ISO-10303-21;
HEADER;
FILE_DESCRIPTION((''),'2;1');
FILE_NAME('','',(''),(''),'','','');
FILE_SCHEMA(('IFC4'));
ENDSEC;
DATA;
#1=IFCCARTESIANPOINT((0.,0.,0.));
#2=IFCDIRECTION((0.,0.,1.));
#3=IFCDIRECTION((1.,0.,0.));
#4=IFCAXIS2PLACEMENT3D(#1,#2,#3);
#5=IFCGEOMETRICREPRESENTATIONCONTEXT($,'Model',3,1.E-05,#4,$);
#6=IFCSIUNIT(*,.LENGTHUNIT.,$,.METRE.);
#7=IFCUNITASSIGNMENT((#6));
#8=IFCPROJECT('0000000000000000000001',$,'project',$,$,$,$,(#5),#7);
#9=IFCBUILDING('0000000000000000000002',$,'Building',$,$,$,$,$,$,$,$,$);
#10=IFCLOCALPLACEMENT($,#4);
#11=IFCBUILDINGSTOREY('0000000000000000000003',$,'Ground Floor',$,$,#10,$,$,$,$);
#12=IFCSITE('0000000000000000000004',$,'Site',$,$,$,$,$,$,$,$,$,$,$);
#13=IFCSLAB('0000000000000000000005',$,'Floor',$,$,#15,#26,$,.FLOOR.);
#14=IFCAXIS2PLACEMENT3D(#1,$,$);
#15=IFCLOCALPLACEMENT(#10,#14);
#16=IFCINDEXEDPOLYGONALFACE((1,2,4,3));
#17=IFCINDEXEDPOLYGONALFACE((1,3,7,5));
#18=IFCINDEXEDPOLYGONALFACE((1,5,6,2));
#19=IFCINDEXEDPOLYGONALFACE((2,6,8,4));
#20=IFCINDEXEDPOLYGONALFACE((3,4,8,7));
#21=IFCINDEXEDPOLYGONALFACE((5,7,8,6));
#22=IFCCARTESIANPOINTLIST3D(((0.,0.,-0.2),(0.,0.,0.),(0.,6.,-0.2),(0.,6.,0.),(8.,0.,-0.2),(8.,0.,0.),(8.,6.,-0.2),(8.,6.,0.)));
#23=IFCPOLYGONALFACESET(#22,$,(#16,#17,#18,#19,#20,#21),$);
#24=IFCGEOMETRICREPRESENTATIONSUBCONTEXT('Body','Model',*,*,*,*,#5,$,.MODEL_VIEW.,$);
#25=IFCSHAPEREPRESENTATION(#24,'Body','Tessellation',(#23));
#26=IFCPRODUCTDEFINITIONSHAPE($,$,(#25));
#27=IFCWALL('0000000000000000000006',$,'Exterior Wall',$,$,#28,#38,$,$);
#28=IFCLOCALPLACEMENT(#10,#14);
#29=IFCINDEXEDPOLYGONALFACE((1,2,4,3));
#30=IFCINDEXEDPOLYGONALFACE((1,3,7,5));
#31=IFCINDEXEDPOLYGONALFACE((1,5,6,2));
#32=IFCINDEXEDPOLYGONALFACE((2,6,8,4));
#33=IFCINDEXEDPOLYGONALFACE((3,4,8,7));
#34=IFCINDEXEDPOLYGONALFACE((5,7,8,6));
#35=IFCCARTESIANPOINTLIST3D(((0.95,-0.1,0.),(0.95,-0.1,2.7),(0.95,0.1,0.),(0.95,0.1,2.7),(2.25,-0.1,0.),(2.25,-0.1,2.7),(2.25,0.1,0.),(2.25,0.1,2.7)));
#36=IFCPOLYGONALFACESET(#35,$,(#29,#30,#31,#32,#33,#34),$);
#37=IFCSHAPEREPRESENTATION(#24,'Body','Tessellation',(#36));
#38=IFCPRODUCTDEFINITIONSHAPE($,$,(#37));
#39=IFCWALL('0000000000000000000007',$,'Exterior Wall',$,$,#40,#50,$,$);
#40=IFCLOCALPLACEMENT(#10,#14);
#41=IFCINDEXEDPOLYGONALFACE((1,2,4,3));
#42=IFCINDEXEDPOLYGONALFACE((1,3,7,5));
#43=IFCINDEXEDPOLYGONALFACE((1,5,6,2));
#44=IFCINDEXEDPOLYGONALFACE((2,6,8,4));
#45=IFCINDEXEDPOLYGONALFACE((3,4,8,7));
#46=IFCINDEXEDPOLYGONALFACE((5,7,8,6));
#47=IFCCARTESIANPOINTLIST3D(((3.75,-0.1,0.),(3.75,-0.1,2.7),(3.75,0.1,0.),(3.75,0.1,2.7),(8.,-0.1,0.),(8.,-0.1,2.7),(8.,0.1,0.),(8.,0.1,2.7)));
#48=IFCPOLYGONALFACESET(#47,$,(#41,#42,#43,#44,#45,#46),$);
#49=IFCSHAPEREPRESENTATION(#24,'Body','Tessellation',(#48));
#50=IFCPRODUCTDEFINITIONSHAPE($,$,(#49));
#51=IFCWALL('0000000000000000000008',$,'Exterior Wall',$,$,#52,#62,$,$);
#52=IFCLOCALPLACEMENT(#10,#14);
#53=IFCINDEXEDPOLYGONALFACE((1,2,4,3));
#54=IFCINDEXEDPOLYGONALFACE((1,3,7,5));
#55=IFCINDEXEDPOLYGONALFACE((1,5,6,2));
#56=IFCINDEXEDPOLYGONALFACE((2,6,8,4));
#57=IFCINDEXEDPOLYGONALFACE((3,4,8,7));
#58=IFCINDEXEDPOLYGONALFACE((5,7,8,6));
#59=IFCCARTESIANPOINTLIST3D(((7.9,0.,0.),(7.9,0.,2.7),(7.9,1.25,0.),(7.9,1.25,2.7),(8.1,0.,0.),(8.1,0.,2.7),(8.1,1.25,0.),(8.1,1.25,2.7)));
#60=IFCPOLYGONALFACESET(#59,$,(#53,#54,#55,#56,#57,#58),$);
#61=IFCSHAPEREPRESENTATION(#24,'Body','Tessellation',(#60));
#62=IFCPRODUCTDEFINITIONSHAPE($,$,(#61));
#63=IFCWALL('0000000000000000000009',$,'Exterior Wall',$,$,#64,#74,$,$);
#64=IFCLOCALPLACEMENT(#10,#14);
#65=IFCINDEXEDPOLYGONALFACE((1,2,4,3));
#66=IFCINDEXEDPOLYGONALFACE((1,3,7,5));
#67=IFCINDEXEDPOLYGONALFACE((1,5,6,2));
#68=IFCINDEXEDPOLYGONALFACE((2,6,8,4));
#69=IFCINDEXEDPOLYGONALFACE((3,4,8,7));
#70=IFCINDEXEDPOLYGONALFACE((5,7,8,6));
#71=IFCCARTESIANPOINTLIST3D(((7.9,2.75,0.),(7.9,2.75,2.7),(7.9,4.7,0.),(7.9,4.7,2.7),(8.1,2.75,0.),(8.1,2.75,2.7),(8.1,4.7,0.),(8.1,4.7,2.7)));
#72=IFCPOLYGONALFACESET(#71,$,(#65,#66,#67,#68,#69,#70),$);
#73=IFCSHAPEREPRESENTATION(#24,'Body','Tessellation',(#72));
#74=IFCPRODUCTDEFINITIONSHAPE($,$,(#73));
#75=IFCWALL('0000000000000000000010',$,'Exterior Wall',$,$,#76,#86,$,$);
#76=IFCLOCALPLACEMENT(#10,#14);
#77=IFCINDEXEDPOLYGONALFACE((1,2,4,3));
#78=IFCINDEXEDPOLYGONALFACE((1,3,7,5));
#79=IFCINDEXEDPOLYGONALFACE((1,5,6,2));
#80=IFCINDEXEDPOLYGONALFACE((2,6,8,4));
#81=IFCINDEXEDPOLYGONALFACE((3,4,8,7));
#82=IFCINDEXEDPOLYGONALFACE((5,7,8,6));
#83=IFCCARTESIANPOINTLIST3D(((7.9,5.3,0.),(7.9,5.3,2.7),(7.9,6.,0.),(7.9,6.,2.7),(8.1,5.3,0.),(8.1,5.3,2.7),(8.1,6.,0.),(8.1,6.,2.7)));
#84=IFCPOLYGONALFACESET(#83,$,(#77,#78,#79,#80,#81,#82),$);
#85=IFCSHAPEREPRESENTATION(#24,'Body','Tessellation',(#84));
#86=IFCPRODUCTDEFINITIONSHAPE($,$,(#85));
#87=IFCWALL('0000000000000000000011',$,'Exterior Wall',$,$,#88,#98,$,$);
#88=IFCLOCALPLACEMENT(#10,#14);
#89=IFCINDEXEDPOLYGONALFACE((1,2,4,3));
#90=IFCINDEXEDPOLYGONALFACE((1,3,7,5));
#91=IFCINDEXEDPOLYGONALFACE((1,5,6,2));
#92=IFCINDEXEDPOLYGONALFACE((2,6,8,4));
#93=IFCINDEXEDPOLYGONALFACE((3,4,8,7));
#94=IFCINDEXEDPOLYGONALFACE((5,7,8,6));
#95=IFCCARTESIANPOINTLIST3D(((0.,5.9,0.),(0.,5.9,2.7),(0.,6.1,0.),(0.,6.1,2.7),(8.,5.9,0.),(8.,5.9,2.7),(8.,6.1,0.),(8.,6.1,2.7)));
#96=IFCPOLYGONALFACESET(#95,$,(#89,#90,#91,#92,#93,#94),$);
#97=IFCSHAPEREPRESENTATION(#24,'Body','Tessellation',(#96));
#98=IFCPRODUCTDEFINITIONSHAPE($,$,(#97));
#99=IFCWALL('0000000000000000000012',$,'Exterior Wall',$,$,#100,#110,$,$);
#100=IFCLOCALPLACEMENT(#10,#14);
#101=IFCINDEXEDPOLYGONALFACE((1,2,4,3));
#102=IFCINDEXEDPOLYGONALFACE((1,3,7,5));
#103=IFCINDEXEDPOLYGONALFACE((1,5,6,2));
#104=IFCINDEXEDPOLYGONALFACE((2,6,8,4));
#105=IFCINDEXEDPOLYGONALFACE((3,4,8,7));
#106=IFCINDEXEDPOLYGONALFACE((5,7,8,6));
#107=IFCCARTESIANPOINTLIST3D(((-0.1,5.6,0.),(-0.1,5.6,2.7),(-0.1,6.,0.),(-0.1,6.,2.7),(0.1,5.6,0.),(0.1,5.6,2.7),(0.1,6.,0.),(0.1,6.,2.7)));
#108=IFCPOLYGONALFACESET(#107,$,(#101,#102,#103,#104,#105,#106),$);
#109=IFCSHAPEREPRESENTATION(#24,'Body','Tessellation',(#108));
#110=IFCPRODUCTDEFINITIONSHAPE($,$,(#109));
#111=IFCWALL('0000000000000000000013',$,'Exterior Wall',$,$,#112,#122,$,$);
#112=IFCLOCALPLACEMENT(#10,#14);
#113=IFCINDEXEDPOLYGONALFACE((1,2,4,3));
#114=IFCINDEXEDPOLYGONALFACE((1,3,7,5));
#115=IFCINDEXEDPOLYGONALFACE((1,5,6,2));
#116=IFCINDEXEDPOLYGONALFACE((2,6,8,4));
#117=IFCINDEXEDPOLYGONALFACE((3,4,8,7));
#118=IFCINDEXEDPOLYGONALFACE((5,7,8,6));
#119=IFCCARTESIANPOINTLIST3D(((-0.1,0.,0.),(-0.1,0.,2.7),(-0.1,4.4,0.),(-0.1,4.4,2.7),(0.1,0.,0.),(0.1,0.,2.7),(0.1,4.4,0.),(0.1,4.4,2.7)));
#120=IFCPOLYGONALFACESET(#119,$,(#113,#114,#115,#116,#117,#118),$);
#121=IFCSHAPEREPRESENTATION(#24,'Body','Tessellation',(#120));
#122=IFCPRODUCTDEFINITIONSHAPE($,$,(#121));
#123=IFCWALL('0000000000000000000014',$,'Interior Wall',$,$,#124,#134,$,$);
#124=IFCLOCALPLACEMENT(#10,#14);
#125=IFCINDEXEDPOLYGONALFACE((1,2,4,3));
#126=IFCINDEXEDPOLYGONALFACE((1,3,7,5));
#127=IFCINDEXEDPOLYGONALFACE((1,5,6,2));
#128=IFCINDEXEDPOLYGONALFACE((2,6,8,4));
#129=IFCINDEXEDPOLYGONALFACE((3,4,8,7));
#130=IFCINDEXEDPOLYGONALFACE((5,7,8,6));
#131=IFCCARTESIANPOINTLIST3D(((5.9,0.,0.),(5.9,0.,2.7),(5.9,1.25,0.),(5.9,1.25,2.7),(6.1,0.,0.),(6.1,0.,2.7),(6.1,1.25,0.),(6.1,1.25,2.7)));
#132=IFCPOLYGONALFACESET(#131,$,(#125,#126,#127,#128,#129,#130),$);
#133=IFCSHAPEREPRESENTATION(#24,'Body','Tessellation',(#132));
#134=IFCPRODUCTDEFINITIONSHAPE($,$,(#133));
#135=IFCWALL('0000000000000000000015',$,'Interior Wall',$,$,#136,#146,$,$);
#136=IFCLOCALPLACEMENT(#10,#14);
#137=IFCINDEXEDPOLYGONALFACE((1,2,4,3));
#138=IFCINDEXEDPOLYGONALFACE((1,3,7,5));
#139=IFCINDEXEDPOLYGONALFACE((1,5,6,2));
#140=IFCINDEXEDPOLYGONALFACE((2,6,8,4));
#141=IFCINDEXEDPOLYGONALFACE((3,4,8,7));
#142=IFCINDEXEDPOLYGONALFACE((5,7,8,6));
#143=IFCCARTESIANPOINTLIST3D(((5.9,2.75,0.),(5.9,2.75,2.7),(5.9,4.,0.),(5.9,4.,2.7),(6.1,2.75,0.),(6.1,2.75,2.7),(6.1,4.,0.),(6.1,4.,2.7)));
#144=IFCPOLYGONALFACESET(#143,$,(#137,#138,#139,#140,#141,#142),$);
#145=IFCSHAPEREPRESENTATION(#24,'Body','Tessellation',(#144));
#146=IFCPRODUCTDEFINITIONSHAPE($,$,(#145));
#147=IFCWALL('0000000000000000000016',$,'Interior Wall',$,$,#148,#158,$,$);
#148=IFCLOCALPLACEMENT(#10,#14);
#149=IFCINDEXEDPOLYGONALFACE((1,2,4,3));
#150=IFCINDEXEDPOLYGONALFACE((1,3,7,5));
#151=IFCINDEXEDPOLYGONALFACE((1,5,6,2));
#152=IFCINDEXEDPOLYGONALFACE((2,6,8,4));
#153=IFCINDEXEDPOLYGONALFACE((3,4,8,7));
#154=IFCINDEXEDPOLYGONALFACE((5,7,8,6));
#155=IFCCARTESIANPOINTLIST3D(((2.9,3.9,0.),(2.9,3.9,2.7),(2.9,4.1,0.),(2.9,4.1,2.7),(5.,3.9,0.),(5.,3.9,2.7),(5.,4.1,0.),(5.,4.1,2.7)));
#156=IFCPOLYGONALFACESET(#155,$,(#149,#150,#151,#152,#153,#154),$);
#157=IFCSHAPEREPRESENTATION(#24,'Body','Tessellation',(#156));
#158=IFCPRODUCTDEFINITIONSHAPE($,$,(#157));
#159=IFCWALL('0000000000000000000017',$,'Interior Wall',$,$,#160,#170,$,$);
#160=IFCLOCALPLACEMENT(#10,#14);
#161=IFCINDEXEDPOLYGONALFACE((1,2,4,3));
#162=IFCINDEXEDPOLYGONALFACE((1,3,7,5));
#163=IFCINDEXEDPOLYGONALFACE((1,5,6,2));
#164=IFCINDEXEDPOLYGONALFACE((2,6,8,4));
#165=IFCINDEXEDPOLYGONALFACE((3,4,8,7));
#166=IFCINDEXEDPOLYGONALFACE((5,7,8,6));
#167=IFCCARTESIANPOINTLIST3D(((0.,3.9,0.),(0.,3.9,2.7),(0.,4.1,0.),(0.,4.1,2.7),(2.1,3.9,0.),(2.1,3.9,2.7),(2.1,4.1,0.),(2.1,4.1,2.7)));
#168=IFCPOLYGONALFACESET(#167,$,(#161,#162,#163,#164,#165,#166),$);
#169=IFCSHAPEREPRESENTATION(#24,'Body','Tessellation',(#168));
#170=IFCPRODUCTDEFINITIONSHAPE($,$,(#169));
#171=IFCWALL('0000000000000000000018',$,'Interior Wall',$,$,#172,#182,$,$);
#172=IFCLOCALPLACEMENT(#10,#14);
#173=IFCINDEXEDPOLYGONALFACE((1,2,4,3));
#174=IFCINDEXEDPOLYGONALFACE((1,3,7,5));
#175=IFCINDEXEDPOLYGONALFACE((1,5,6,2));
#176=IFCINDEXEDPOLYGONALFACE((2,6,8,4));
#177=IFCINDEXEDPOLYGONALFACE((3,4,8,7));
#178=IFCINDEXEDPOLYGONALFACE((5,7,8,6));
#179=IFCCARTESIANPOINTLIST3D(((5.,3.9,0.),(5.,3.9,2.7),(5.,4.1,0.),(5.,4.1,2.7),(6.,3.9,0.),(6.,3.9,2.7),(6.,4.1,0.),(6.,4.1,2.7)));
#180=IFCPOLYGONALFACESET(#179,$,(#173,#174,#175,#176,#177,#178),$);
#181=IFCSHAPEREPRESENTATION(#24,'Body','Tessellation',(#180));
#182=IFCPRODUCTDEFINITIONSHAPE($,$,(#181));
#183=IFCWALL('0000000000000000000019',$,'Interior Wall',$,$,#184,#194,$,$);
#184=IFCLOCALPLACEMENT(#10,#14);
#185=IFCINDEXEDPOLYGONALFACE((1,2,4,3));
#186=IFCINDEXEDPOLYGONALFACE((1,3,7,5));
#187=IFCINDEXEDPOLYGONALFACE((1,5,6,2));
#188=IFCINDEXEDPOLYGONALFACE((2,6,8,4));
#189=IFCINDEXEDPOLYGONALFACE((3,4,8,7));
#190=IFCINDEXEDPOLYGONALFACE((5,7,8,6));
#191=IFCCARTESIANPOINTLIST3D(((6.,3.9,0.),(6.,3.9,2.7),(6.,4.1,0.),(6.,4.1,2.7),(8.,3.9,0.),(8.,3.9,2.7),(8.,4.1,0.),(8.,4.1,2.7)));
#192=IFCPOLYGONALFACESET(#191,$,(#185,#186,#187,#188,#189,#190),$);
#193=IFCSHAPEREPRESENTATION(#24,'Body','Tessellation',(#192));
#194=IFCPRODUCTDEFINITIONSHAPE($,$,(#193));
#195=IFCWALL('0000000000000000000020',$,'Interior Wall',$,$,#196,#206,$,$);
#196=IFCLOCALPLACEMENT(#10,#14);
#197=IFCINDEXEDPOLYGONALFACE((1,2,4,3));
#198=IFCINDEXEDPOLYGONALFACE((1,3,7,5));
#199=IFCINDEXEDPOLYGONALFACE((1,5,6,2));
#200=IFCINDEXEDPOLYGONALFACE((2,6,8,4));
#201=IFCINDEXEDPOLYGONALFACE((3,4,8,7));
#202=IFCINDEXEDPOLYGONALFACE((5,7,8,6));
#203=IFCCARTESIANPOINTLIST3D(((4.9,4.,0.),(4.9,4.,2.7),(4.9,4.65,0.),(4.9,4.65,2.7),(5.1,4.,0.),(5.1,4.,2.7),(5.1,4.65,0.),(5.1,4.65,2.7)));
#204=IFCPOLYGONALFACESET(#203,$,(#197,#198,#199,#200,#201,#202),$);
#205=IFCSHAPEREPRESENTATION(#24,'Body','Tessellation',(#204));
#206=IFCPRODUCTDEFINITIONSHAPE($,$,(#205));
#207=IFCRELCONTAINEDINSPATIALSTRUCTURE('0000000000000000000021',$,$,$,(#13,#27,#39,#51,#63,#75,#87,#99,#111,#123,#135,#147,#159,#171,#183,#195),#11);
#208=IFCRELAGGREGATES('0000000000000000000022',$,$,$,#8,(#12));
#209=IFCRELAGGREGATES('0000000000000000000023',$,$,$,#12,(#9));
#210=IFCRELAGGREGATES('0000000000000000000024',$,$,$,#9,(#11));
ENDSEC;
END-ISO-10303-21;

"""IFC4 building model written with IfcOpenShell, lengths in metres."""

from ifc_helpers import new_model, si_unit, frame, origin_with_axes, place, context, subcontext, project, spatial, indexed_curve, outline, extrude, element, save


model = new_model("IFC4")

# Units and contexts
model_context = context("Model", 3, precision=1e-05, world=origin_with_axes())
body_context = subcontext(model_context, "Body", "Model", "MODEL_VIEW")
ifc_project = project(units=[si_unit("LENGTHUNIT", "METRE")], contexts=[model_context])

# Site, building, storey
site = spatial("IfcSite", under=ifc_project, Name="Site")
building = spatial("IfcBuilding", under=site, Name="Building")
storey_placement = place(None, origin_with_axes())
storey = spatial("IfcBuildingStorey", under=building, at=storey_placement, Name="Ground Floor")

# Slab
slab_placement = place(storey_placement, frame((0.0, 0.0, -0.2), z_axis=(0.0, 0.0, 1.0), x_axis=(1.0, 0.0, 0.0)))
element("IfcSlab", 1, at=slab_placement, inside=storey, Name="Floor", PredefinedType="FLOOR", context=body_context, shape_type="SweptSolid", body=[
    extrude(outline(indexed_curve([(0.0, 0.0), (8.0, 0.0), (8.0, 6.0), (0.0, 6.0)])), None, (0.0, 0.0, 1.0), 0.2),
])

# Walls
wall_1_placement = place(storey_placement, frame((0.95, 0.0, 0.0), z_axis=(0.0, 0.0, 1.0), x_axis=(1.0, 0.0, 0.0)))
element("IfcWall", 2, at=wall_1_placement, inside=storey, Name="Exterior Wall", context=body_context, shape_type="SweptSolid", body=[
    extrude(outline(indexed_curve([(0.0, 0.0), (0.0, 0.2), (1.3, 0.2), (1.3, 0.0), (0.0, 0.0)], self_intersect=False)), frame((0.0, -0.1, 0.0), z_axis=(0.0, 0.0, 1.0), x_axis=(1.0, 0.0, 0.0)), (0.0, 0.0, 1.0), 2.7),
])
wall_2_placement = place(storey_placement, frame((3.75, 0.0, 0.0), z_axis=(0.0, 0.0, 1.0), x_axis=(1.0, 0.0, 0.0)))
element("IfcWall", 3, at=wall_2_placement, inside=storey, Name="Exterior Wall", context=body_context, shape_type="SweptSolid", body=[
    extrude(outline(indexed_curve([(0.0, 0.0), (0.0, 0.2), (4.25, 0.2), (4.25, 0.0), (0.0, 0.0)], self_intersect=False)), frame((0.0, -0.1, 0.0), z_axis=(0.0, 0.0, 1.0), x_axis=(1.0, 0.0, 0.0)), (0.0, 0.0, 1.0), 2.7),
])
wall_3_placement = place(storey_placement, frame((8.0, 0.0, 0.0), z_axis=(0.0, 0.0, 1.0), x_axis=(0.0, 1.0, 0.0)))
element("IfcWall", 4, at=wall_3_placement, inside=storey, Name="Exterior Wall", context=body_context, shape_type="SweptSolid", body=[
    extrude(outline(indexed_curve([(0.0, 0.0), (0.0, 0.2), (1.25, 0.2), (1.25, 0.0), (0.0, 0.0)], self_intersect=False)), frame((0.0, -0.1, 0.0), z_axis=(0.0, 0.0, 1.0), x_axis=(1.0, 0.0, 0.0)), (0.0, 0.0, 1.0), 2.7),
])
wall_4_placement = place(storey_placement, frame((8.0, 2.75, 0.0), z_axis=(0.0, 0.0, 1.0), x_axis=(0.0, 1.0, 0.0)))
element("IfcWall", 5, at=wall_4_placement, inside=storey, Name="Exterior Wall", context=body_context, shape_type="SweptSolid", body=[
    extrude(outline(indexed_curve([(0.0, 0.0), (0.0, 0.2), (1.95, 0.2), (1.95, 0.0), (0.0, 0.0)], self_intersect=False)), frame((0.0, -0.1, 0.0), z_axis=(0.0, 0.0, 1.0), x_axis=(1.0, 0.0, 0.0)), (0.0, 0.0, 1.0), 2.7),
])
wall_5_placement = place(storey_placement, frame((8.0, 5.3, 0.0), z_axis=(0.0, 0.0, 1.0), x_axis=(0.0, 1.0, 0.0)))
element("IfcWall", 6, at=wall_5_placement, inside=storey, Name="Exterior Wall", context=body_context, shape_type="SweptSolid", body=[
    extrude(outline(indexed_curve([(0.0, 0.0), (0.0, 0.2), (0.7, 0.2), (0.7, 0.0), (0.0, 0.0)], self_intersect=False)), frame((0.0, -0.1, 0.0), z_axis=(0.0, 0.0, 1.0), x_axis=(1.0, 0.0, 0.0)), (0.0, 0.0, 1.0), 2.7),
])
wall_6_placement = place(storey_placement, frame((8.0, 6.0, 0.0), z_axis=(0.0, 0.0, 1.0), x_axis=(-1.0, 0.0, 0.0)))
element("IfcWall", 7, at=wall_6_placement, inside=storey, Name="Exterior Wall", context=body_context, shape_type="SweptSolid", body=[
    extrude(outline(indexed_curve([(0.0, 0.0), (0.0, 0.2), (8.0, 0.2), (8.0, 0.0), (0.0, 0.0)], self_intersect=False)), frame((0.0, -0.1, 0.0), z_axis=(0.0, 0.0, 1.0), x_axis=(1.0, 0.0, 0.0)), (0.0, 0.0, 1.0), 2.7),
])
wall_7_placement = place(storey_placement, frame((0.0, 6.0, 0.0), z_axis=(0.0, 0.0, 1.0), x_axis=(0.0, -1.0, 0.0)))
element("IfcWall", 8, at=wall_7_placement, inside=storey, Name="Exterior Wall", context=body_context, shape_type="SweptSolid", body=[
    extrude(outline(indexed_curve([(0.0, 0.0), (0.0, 0.2), (0.4, 0.2), (0.4, 0.0), (0.0, 0.0)], self_intersect=False)), frame((0.0, -0.1, 0.0), z_axis=(0.0, 0.0, 1.0), x_axis=(1.0, 0.0, 0.0)), (0.0, 0.0, 1.0), 2.7),
])
wall_8_placement = place(storey_placement, frame((0.0, 4.4, 0.0), z_axis=(0.0, 0.0, 1.0), x_axis=(0.0, -1.0, 0.0)))
element("IfcWall", 9, at=wall_8_placement, inside=storey, Name="Exterior Wall", context=body_context, shape_type="SweptSolid", body=[
    extrude(outline(indexed_curve([(0.0, 0.0), (0.0, 0.2), (4.4, 0.2), (4.4, 0.0), (0.0, 0.0)], self_intersect=False)), frame((0.0, -0.1, 0.0), z_axis=(0.0, 0.0, 1.0), x_axis=(1.0, 0.0, 0.0)), (0.0, 0.0, 1.0), 2.7),
])
for number, where, z_axis, x_axis, name in (
    (10, (6.0, 0.0, 0.0), (0.0, 0.0, 1.0), (0.0, 1.0, 0.0), "Interior Wall"),
    (11, (6.0, 2.75, 0.0), (0.0, 0.0, 1.0), (0.0, 1.0, 0.0), "Interior Wall"),
):
    element("IfcWall", number, at=place(storey_placement, frame(where, z_axis=z_axis, x_axis=x_axis)), inside=storey, Name=name, context=body_context, shape_type="SweptSolid", body=[
        extrude(outline(indexed_curve([(0.0, 0.0), (0.0, 0.2), (1.25, 0.2), (1.25, 0.0), (0.0, 0.0)], self_intersect=False)), frame((0.0, -0.1, 0.0), z_axis=(0.0, 0.0, 1.0), x_axis=(1.0, 0.0, 0.0)), (0.0, 0.0, 1.0), 2.7),
    ])
for number, where, z_axis, x_axis, name in (
    (12, (5.0, 4.0, 0.0), (0.0, 0.0, 1.0), (-1.0, 0.0, 0.0), "Interior Wall"),
    (13, (2.1, 4.0, 0.0), (0.0, 0.0, 1.0), (-1.0, 0.0, 0.0), "Interior Wall"),
):
    element("IfcWall", number, at=place(storey_placement, frame(where, z_axis=z_axis, x_axis=x_axis)), inside=storey, Name=name, context=body_context, shape_type="SweptSolid", body=[
        extrude(outline(indexed_curve([(0.0, 0.0), (0.0, 0.2), (2.1, 0.2), (2.1, 0.0), (0.0, 0.0)], self_intersect=False)), frame((0.0, -0.1, 0.0), z_axis=(0.0, 0.0, 1.0), x_axis=(1.0, 0.0, 0.0)), (0.0, 0.0, 1.0), 2.7),
    ])
wall_9_placement = place(storey_placement, frame((6.0, 4.0, 0.0), z_axis=(0.0, 0.0, 1.0), x_axis=(-1.0, 0.0, 0.0)))
element("IfcWall", 14, at=wall_9_placement, inside=storey, Name="Interior Wall", context=body_context, shape_type="SweptSolid", body=[
    extrude(outline(indexed_curve([(0.0, 0.0), (0.0, 0.2), (1.0, 0.2), (1.0, 0.0), (0.0, 0.0)], self_intersect=False)), frame((0.0, -0.1, 0.0), z_axis=(0.0, 0.0, 1.0), x_axis=(1.0, 0.0, 0.0)), (0.0, 0.0, 1.0), 2.7),
])
wall_10_placement = place(storey_placement, frame((8.0, 4.0, 0.0), z_axis=(0.0, 0.0, 1.0), x_axis=(-1.0, 0.0, 0.0)))
element("IfcWall", 15, at=wall_10_placement, inside=storey, Name="Interior Wall", context=body_context, shape_type="SweptSolid", body=[
    extrude(outline(indexed_curve([(0.0, 0.0), (0.0, 0.2), (2.0, 0.2), (2.0, 0.0), (0.0, 0.0)], self_intersect=False)), frame((0.0, -0.1, 0.0), z_axis=(0.0, 0.0, 1.0), x_axis=(1.0, 0.0, 0.0)), (0.0, 0.0, 1.0), 2.7),
])
for number, where, z_axis, x_axis, name in (
    (16, (5.0, 4.0, 0.0), (0.0, 0.0, 1.0), (0.0, 1.0, 0.0), "Interior Wall"),
):
    element("IfcWall", number, at=place(storey_placement, frame(where, z_axis=z_axis, x_axis=x_axis)), inside=storey, Name=name, context=body_context, shape_type="SweptSolid", body=[
        extrude(outline(indexed_curve([(0.0, 0.0), (0.0, 0.2), (0.65, 0.2), (0.65, 0.0), (0.0, 0.0)], self_intersect=False)), frame((0.0, -0.1, 0.0), z_axis=(0.0, 0.0, 1.0), x_axis=(1.0, 0.0, 0.0)), (0.0, 0.0, 1.0), 2.7),
    ])

save(model, "model.ifc")
